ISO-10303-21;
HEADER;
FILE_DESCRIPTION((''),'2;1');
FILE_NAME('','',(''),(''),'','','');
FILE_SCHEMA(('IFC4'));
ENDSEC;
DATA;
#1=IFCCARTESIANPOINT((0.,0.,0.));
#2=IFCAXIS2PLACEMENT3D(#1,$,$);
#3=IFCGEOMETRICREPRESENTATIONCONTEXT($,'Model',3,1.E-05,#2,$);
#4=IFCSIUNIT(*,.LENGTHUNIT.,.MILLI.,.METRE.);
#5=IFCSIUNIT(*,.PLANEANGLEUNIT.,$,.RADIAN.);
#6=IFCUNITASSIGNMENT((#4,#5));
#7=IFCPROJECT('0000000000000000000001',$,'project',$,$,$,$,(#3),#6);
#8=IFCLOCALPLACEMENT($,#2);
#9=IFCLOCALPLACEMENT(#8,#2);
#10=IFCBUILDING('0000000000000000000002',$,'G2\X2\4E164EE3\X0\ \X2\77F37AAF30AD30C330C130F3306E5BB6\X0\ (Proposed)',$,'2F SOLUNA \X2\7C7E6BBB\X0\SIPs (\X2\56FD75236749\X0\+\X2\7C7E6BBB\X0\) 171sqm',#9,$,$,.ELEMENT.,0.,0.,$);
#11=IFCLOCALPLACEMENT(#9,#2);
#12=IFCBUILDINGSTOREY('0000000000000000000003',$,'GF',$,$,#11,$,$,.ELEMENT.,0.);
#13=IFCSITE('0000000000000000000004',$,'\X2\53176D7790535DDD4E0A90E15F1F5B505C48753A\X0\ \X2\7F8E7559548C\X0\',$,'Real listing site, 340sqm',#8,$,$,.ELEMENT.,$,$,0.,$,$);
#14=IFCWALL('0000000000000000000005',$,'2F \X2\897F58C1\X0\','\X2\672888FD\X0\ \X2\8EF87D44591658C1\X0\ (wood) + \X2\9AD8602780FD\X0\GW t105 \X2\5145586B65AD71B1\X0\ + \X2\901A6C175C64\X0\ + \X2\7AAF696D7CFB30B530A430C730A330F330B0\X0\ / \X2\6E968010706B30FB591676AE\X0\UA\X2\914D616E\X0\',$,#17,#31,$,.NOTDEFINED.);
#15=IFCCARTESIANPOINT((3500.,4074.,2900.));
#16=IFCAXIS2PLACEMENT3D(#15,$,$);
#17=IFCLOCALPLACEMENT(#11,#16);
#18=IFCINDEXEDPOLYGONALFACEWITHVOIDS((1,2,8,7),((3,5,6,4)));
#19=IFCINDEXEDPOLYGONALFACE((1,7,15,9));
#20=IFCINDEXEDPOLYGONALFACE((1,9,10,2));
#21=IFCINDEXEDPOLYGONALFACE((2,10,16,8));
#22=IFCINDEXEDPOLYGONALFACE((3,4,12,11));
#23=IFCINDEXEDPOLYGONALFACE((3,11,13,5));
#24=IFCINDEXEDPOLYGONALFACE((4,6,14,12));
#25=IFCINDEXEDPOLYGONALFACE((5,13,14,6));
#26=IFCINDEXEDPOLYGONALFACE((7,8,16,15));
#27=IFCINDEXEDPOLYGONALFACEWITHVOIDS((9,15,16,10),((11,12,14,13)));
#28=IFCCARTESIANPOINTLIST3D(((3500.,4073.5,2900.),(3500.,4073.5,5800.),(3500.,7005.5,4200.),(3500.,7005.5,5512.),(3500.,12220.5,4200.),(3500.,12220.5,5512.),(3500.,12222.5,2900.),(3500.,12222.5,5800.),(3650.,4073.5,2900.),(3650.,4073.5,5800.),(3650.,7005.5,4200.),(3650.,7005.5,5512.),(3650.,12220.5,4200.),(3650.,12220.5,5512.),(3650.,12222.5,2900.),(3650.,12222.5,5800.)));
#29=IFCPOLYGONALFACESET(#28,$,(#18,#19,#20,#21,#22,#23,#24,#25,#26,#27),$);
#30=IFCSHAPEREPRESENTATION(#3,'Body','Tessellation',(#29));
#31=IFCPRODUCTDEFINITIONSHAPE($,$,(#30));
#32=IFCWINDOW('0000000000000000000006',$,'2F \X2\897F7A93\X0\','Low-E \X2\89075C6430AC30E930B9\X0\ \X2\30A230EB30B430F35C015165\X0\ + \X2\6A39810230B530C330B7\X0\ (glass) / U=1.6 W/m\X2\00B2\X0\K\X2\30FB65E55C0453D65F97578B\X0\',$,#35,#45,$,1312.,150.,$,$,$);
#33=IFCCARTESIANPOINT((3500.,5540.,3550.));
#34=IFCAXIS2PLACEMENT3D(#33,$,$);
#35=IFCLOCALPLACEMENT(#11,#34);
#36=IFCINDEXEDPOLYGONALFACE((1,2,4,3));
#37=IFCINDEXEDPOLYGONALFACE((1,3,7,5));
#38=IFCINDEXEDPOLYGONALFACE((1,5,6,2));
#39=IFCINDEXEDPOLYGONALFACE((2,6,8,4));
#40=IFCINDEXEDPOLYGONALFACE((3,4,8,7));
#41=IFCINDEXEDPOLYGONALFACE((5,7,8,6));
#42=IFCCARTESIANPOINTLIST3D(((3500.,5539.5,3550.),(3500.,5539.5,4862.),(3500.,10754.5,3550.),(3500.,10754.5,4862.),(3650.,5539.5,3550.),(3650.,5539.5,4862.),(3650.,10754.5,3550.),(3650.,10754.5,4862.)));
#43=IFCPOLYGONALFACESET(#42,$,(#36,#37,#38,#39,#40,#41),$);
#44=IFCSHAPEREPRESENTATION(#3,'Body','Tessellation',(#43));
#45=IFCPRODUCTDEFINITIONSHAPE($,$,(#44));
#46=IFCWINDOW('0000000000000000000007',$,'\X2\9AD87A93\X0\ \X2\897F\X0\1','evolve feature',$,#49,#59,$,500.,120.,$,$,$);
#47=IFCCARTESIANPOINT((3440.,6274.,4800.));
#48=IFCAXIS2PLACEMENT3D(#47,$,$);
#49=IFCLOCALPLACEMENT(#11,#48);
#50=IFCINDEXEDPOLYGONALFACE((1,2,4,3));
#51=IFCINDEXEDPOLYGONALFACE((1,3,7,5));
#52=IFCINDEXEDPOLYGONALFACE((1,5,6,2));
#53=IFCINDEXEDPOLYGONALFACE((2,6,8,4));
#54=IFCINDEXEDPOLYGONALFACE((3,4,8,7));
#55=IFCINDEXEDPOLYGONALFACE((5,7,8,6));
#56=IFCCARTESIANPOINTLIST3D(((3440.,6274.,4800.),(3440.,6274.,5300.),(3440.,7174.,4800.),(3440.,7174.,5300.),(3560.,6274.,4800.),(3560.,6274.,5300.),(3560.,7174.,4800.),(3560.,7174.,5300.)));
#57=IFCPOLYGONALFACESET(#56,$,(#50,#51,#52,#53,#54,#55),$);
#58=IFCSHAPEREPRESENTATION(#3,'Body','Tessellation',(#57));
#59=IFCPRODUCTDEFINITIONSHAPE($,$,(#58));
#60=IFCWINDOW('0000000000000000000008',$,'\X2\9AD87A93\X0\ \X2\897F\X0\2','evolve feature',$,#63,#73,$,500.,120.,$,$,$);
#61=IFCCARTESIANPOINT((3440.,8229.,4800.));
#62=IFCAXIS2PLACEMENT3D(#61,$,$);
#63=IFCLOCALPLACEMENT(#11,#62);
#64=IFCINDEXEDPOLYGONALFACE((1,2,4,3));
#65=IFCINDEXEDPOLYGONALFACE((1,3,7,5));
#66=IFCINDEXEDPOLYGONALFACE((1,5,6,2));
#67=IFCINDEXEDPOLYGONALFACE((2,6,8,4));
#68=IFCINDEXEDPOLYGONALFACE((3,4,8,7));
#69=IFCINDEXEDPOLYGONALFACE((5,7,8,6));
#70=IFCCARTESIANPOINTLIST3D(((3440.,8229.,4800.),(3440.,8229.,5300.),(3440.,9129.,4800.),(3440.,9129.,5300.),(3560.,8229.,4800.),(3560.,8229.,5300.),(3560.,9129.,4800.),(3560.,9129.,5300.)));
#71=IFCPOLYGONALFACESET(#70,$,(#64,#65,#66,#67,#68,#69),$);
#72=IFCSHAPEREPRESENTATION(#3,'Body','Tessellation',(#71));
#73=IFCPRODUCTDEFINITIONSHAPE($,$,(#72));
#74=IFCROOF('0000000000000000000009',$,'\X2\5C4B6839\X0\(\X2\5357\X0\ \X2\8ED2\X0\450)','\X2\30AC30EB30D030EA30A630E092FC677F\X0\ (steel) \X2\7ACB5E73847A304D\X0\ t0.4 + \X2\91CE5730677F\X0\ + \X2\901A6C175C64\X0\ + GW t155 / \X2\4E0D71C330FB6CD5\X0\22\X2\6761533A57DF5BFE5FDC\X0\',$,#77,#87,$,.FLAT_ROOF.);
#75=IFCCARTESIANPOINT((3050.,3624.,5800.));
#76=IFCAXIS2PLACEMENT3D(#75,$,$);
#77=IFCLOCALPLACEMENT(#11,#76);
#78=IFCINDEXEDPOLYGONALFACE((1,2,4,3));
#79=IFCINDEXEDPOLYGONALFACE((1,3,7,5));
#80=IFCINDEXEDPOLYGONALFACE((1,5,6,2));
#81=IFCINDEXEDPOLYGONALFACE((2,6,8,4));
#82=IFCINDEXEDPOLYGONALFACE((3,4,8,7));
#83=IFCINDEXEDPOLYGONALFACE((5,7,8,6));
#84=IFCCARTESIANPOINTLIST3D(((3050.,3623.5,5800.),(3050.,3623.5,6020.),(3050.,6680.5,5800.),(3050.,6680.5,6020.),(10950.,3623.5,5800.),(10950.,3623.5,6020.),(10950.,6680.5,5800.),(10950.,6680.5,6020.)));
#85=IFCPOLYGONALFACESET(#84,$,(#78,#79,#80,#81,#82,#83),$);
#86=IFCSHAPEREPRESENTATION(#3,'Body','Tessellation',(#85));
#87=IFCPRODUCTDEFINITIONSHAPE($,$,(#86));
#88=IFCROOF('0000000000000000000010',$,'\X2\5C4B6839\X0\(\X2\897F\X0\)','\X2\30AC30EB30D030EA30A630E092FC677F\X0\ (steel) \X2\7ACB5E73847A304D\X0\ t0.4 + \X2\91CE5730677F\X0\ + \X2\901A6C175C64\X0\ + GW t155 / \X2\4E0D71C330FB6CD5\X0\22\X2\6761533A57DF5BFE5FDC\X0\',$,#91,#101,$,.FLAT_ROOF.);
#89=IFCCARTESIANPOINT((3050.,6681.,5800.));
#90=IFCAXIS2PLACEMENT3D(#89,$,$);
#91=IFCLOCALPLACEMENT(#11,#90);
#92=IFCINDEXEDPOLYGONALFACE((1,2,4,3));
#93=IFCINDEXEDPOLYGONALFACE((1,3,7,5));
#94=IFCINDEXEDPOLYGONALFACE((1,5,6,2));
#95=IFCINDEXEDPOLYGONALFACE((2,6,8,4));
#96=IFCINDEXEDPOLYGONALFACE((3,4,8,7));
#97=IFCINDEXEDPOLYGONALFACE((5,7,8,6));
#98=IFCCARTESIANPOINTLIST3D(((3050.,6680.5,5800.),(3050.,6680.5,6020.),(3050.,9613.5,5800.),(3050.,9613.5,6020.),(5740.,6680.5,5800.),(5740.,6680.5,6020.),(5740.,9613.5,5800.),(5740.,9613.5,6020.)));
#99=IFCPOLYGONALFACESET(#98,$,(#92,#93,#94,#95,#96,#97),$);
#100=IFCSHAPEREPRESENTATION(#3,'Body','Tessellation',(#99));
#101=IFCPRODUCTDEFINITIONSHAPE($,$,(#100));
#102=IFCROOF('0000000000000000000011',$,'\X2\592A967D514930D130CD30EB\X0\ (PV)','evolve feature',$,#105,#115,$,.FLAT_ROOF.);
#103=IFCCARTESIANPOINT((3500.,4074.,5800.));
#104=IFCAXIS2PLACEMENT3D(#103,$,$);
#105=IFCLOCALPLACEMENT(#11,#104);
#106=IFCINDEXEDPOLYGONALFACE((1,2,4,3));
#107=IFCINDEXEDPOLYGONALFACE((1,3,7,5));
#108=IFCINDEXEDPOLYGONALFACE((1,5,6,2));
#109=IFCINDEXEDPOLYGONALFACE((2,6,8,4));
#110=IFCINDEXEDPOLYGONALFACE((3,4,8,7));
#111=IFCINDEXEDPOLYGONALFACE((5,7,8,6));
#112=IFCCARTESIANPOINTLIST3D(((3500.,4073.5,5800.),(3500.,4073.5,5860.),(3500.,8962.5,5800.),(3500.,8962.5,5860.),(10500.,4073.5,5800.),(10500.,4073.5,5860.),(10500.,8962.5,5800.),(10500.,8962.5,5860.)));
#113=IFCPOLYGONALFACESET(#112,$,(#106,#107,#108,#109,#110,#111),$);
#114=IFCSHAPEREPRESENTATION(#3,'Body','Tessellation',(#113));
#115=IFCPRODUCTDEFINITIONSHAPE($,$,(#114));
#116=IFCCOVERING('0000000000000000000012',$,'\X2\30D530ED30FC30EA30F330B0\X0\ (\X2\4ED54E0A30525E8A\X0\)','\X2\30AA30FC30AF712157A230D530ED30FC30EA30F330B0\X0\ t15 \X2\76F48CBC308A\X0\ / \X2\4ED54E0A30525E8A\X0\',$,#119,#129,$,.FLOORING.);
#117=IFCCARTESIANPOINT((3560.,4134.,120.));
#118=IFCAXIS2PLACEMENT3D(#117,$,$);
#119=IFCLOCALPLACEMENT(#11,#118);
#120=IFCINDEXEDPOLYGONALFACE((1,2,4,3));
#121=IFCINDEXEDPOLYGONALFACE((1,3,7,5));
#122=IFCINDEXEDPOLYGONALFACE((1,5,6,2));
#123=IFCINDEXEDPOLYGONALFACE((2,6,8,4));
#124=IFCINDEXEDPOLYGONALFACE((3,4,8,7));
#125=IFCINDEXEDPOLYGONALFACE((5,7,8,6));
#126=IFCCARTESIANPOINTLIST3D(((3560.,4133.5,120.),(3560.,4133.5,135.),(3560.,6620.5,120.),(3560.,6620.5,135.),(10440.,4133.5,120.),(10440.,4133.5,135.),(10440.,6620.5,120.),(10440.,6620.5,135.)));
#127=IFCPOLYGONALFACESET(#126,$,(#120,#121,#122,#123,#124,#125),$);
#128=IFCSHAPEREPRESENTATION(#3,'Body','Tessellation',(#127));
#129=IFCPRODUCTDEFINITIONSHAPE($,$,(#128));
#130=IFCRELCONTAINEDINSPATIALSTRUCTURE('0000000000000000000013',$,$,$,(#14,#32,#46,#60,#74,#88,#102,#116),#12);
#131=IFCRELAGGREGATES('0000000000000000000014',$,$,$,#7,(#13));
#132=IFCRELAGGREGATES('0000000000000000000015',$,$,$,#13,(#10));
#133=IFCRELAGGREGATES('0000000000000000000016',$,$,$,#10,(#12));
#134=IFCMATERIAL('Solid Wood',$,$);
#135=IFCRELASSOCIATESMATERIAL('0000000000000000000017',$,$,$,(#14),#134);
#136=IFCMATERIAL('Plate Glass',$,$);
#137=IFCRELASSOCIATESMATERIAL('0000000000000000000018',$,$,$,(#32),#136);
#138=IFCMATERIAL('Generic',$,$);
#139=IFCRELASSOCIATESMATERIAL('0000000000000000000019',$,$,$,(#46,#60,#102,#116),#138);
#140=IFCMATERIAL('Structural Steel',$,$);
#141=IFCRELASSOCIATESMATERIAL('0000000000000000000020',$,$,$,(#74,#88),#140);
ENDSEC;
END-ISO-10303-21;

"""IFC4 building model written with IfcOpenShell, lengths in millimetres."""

from ifc_helpers import new_model, si_unit, frame, frame_2d, origin, place, context, project, spatial, rectangle, extrude, material, element, fill, save


model = new_model("IFC4")

# Units and contexts
model_context = context("Model", 3, precision=1e-05, world=origin())
ifc_project = project(units=[si_unit("LENGTHUNIT", "METRE", prefix="MILLI"), si_unit("PLANEANGLEUNIT", "RADIAN")], contexts=[model_context])

# Site, building, storey
site_placement = place(None, origin())
site = spatial("IfcSite", under=ifc_project, at=site_placement, Name="北海道川上郡弟子屈町 美留和", ObjectType="Real listing site, 340sqm", CompositionType="ELEMENT", RefElevation=0.0)
building_placement = place(site_placement, origin())
building = spatial("IfcBuilding", under=site, at=building_placement, Name="G2世代 石窯キッチンの家 (Proposed)", ObjectType="2F SOLUNA 籾殻SIPs (国産杉+籾殻) 171sqm", CompositionType="ELEMENT", ElevationOfRefHeight=0.0, ElevationOfTerrain=0.0)
storey_placement = place(building_placement, origin())
storey = spatial("IfcBuildingStorey", under=building, at=storey_placement, Name="GF", CompositionType="ELEMENT", Elevation=0.0)

# Shared definitions
ifc_material_1 = material(Name="Solid Wood")
ifc_material_2 = material(Name="Generic")

# Shared definitions
ifc_material_3 = material(Name="Plate Glass")

# Wall, openings, windows
wall_1_placement = place(storey_placement, frame((3500.0, 4074.0, 2900.0)))
wall_1 = element("IfcWall", 1, at=wall_1_placement, inside=storey, material=ifc_material_1, Name="2F 西壁", Description="木製 軸組外壁 (wood) + 高性能GW t105 充填断熱 + 通気層 + 窯業系サイディング / 準耐火・外皮UA配慮", PredefinedType="NOTDEFINED", context=model_context, shape_type="SweptSolid", body=[
    extrude(rectangle(XDim=150.0, YDim=8149.0, at=frame_2d((75.0, 4074.0))), frame((3500.0, 4074.0, 2900.0)), (0.0, 0.0, 1.0), 2900.0),
])
opening_1_placement = place(storey_placement, frame((3500.0, 5540.0, 3550.0)))
opening_1 = element("IfcOpeningElement", 2, at=opening_1_placement, cuts=wall_1, PredefinedType="NOTDEFINED", context=model_context, shape_type="SweptSolid", body=[
    extrude(rectangle(XDim=150.0, YDim=5215.0, at=frame_2d((75.0, 2607.0))), frame((3500.0, 5540.0, 3550.0)), (0.0, 0.0, 1.0), 1312.0),
])
opening_2_placement = place(storey_placement, frame((3440.0, 6274.0, 4800.0)))
opening_2 = element("IfcOpeningElement", 3, at=opening_2_placement, cuts=wall_1, PredefinedType="NOTDEFINED", context=model_context, shape_type="SweptSolid", body=[
    extrude(rectangle(XDim=120.0, YDim=900.0, at=frame_2d((60.0, 450.0))), frame((3440.0, 6274.0, 4800.0)), (0.0, 0.0, 1.0), 500.0),
])
opening_3_placement = place(storey_placement, frame((3440.0, 8229.0, 4800.0)))
opening_3 = element("IfcOpeningElement", 4, at=opening_3_placement, cuts=wall_1, PredefinedType="NOTDEFINED", context=model_context, shape_type="SweptSolid", body=[
    extrude(rectangle(XDim=120.0, YDim=900.0, at=frame_2d((60.0, 450.0))), frame((3440.0, 8229.0, 4800.0)), (0.0, 0.0, 1.0), 500.0),
])
window_1_placement = place(storey_placement, frame((3500.0, 5540.0, 3550.0)))
window_1 = element("IfcWindow", 5, at=window_1_placement, inside=storey, material=ifc_material_3, Name="2F 西窓", Description="Low-E 複層ガラス アルゴン封入 + 樹脂サッシ (glass) / U=1.6 W/m²K・日射取得型", OverallHeight=1312.0, OverallWidth=150.0, context=model_context, shape_type="SweptSolid", body=[
    extrude(rectangle(XDim=150.0, YDim=5215.0, at=frame_2d((75.0, 2607.0))), frame((3500.0, 5540.0, 3550.0)), (0.0, 0.0, 1.0), 1312.0),
])
fill(opening_1, window_1)
window_2_placement = place(storey_placement, frame((3440.0, 6274.0, 4800.0)))
window_2 = element("IfcWindow", 6, at=window_2_placement, inside=storey, material=ifc_material_2, Name="高窓 西1", Description="evolve feature", OverallHeight=500.0, OverallWidth=120.0, context=model_context, shape_type="SweptSolid", body=[
    extrude(rectangle(XDim=120.0, YDim=900.0, at=frame_2d((60.0, 450.0))), frame((3440.0, 6274.0, 4800.0)), (0.0, 0.0, 1.0), 500.0),
])
fill(opening_2, window_2)
window_3_placement = place(storey_placement, frame((3440.0, 8229.0, 4800.0)))
window_3 = element("IfcWindow", 7, at=window_3_placement, inside=storey, material=ifc_material_2, Name="高窓 西2", Description="evolve feature", OverallHeight=500.0, OverallWidth=120.0, context=model_context, shape_type="SweptSolid", body=[
    extrude(rectangle(XDim=120.0, YDim=900.0, at=frame_2d((60.0, 450.0))), frame((3440.0, 8229.0, 4800.0)), (0.0, 0.0, 1.0), 500.0),
])
fill(opening_3, window_3)

# Roofs
ifc_material_4 = material(Name="Structural Steel")
roof_1_placement = place(storey_placement, frame((3050.0, 3624.0, 5800.0)))
element("IfcRoof", 8, at=roof_1_placement, inside=storey, material=ifc_material_4, Name="屋根(南 軒450)", Description="ガルバリウム鋼板 (steel) 立平葺き t0.4 + 野地板 + 通気層 + GW t155 / 不燃・法22条区域対応", PredefinedType="FLAT_ROOF", context=model_context, shape_type="SweptSolid", body=[
    extrude(rectangle(XDim=7900.0, YDim=3057.0, at=frame_2d((3950.0, 1528.0))), frame((3050.0, 3624.0, 5800.0)), (0.0, 0.0, 1.0), 220.0),
])
roof_2_placement = place(storey_placement, frame((3050.0, 6681.0, 5800.0)))
element("IfcRoof", 9, at=roof_2_placement, inside=storey, material=ifc_material_4, Name="屋根(西)", Description="ガルバリウム鋼板 (steel) 立平葺き t0.4 + 野地板 + 通気層 + GW t155 / 不燃・法22条区域対応", PredefinedType="FLAT_ROOF", context=model_context, shape_type="SweptSolid", body=[
    extrude(rectangle(XDim=2690.0, YDim=2933.0, at=frame_2d((1345.0, 1466.0))), frame((3050.0, 6681.0, 5800.0)), (0.0, 0.0, 1.0), 220.0),
])
roof_3_placement = place(storey_placement, frame((3500.0, 4074.0, 5800.0)))
element("IfcRoof", 10, at=roof_3_placement, inside=storey, material=ifc_material_2, Name="太陽光パネル (PV)", Description="evolve feature", PredefinedType="FLAT_ROOF", context=model_context, shape_type="SweptSolid", body=[
    extrude(rectangle(XDim=7000.0, YDim=4889.0, at=frame_2d((3500.0, 2444.0))), frame((3500.0, 4074.0, 5800.0)), (0.0, 0.0, 1.0), 60.0),
])

# Covering
covering_placement = place(storey_placement, frame((3560.0, 4134.0, 120.0)))
element("IfcCovering", 11, at=covering_placement, inside=storey, material=ifc_material_2, Name="フローリング (仕上げ床)", Description="オーク無垢フローリング t15 直貼り / 仕上げ床", PredefinedType="FLOORING", context=model_context, shape_type="SweptSolid", body=[
    extrude(rectangle(XDim=6880.0, YDim=2487.0, at=frame_2d((3440.0, 1243.0))), frame((3560.0, 4134.0, 120.0)), (0.0, 0.0, 1.0), 15.0),
])

save(model, "model.ifc")
